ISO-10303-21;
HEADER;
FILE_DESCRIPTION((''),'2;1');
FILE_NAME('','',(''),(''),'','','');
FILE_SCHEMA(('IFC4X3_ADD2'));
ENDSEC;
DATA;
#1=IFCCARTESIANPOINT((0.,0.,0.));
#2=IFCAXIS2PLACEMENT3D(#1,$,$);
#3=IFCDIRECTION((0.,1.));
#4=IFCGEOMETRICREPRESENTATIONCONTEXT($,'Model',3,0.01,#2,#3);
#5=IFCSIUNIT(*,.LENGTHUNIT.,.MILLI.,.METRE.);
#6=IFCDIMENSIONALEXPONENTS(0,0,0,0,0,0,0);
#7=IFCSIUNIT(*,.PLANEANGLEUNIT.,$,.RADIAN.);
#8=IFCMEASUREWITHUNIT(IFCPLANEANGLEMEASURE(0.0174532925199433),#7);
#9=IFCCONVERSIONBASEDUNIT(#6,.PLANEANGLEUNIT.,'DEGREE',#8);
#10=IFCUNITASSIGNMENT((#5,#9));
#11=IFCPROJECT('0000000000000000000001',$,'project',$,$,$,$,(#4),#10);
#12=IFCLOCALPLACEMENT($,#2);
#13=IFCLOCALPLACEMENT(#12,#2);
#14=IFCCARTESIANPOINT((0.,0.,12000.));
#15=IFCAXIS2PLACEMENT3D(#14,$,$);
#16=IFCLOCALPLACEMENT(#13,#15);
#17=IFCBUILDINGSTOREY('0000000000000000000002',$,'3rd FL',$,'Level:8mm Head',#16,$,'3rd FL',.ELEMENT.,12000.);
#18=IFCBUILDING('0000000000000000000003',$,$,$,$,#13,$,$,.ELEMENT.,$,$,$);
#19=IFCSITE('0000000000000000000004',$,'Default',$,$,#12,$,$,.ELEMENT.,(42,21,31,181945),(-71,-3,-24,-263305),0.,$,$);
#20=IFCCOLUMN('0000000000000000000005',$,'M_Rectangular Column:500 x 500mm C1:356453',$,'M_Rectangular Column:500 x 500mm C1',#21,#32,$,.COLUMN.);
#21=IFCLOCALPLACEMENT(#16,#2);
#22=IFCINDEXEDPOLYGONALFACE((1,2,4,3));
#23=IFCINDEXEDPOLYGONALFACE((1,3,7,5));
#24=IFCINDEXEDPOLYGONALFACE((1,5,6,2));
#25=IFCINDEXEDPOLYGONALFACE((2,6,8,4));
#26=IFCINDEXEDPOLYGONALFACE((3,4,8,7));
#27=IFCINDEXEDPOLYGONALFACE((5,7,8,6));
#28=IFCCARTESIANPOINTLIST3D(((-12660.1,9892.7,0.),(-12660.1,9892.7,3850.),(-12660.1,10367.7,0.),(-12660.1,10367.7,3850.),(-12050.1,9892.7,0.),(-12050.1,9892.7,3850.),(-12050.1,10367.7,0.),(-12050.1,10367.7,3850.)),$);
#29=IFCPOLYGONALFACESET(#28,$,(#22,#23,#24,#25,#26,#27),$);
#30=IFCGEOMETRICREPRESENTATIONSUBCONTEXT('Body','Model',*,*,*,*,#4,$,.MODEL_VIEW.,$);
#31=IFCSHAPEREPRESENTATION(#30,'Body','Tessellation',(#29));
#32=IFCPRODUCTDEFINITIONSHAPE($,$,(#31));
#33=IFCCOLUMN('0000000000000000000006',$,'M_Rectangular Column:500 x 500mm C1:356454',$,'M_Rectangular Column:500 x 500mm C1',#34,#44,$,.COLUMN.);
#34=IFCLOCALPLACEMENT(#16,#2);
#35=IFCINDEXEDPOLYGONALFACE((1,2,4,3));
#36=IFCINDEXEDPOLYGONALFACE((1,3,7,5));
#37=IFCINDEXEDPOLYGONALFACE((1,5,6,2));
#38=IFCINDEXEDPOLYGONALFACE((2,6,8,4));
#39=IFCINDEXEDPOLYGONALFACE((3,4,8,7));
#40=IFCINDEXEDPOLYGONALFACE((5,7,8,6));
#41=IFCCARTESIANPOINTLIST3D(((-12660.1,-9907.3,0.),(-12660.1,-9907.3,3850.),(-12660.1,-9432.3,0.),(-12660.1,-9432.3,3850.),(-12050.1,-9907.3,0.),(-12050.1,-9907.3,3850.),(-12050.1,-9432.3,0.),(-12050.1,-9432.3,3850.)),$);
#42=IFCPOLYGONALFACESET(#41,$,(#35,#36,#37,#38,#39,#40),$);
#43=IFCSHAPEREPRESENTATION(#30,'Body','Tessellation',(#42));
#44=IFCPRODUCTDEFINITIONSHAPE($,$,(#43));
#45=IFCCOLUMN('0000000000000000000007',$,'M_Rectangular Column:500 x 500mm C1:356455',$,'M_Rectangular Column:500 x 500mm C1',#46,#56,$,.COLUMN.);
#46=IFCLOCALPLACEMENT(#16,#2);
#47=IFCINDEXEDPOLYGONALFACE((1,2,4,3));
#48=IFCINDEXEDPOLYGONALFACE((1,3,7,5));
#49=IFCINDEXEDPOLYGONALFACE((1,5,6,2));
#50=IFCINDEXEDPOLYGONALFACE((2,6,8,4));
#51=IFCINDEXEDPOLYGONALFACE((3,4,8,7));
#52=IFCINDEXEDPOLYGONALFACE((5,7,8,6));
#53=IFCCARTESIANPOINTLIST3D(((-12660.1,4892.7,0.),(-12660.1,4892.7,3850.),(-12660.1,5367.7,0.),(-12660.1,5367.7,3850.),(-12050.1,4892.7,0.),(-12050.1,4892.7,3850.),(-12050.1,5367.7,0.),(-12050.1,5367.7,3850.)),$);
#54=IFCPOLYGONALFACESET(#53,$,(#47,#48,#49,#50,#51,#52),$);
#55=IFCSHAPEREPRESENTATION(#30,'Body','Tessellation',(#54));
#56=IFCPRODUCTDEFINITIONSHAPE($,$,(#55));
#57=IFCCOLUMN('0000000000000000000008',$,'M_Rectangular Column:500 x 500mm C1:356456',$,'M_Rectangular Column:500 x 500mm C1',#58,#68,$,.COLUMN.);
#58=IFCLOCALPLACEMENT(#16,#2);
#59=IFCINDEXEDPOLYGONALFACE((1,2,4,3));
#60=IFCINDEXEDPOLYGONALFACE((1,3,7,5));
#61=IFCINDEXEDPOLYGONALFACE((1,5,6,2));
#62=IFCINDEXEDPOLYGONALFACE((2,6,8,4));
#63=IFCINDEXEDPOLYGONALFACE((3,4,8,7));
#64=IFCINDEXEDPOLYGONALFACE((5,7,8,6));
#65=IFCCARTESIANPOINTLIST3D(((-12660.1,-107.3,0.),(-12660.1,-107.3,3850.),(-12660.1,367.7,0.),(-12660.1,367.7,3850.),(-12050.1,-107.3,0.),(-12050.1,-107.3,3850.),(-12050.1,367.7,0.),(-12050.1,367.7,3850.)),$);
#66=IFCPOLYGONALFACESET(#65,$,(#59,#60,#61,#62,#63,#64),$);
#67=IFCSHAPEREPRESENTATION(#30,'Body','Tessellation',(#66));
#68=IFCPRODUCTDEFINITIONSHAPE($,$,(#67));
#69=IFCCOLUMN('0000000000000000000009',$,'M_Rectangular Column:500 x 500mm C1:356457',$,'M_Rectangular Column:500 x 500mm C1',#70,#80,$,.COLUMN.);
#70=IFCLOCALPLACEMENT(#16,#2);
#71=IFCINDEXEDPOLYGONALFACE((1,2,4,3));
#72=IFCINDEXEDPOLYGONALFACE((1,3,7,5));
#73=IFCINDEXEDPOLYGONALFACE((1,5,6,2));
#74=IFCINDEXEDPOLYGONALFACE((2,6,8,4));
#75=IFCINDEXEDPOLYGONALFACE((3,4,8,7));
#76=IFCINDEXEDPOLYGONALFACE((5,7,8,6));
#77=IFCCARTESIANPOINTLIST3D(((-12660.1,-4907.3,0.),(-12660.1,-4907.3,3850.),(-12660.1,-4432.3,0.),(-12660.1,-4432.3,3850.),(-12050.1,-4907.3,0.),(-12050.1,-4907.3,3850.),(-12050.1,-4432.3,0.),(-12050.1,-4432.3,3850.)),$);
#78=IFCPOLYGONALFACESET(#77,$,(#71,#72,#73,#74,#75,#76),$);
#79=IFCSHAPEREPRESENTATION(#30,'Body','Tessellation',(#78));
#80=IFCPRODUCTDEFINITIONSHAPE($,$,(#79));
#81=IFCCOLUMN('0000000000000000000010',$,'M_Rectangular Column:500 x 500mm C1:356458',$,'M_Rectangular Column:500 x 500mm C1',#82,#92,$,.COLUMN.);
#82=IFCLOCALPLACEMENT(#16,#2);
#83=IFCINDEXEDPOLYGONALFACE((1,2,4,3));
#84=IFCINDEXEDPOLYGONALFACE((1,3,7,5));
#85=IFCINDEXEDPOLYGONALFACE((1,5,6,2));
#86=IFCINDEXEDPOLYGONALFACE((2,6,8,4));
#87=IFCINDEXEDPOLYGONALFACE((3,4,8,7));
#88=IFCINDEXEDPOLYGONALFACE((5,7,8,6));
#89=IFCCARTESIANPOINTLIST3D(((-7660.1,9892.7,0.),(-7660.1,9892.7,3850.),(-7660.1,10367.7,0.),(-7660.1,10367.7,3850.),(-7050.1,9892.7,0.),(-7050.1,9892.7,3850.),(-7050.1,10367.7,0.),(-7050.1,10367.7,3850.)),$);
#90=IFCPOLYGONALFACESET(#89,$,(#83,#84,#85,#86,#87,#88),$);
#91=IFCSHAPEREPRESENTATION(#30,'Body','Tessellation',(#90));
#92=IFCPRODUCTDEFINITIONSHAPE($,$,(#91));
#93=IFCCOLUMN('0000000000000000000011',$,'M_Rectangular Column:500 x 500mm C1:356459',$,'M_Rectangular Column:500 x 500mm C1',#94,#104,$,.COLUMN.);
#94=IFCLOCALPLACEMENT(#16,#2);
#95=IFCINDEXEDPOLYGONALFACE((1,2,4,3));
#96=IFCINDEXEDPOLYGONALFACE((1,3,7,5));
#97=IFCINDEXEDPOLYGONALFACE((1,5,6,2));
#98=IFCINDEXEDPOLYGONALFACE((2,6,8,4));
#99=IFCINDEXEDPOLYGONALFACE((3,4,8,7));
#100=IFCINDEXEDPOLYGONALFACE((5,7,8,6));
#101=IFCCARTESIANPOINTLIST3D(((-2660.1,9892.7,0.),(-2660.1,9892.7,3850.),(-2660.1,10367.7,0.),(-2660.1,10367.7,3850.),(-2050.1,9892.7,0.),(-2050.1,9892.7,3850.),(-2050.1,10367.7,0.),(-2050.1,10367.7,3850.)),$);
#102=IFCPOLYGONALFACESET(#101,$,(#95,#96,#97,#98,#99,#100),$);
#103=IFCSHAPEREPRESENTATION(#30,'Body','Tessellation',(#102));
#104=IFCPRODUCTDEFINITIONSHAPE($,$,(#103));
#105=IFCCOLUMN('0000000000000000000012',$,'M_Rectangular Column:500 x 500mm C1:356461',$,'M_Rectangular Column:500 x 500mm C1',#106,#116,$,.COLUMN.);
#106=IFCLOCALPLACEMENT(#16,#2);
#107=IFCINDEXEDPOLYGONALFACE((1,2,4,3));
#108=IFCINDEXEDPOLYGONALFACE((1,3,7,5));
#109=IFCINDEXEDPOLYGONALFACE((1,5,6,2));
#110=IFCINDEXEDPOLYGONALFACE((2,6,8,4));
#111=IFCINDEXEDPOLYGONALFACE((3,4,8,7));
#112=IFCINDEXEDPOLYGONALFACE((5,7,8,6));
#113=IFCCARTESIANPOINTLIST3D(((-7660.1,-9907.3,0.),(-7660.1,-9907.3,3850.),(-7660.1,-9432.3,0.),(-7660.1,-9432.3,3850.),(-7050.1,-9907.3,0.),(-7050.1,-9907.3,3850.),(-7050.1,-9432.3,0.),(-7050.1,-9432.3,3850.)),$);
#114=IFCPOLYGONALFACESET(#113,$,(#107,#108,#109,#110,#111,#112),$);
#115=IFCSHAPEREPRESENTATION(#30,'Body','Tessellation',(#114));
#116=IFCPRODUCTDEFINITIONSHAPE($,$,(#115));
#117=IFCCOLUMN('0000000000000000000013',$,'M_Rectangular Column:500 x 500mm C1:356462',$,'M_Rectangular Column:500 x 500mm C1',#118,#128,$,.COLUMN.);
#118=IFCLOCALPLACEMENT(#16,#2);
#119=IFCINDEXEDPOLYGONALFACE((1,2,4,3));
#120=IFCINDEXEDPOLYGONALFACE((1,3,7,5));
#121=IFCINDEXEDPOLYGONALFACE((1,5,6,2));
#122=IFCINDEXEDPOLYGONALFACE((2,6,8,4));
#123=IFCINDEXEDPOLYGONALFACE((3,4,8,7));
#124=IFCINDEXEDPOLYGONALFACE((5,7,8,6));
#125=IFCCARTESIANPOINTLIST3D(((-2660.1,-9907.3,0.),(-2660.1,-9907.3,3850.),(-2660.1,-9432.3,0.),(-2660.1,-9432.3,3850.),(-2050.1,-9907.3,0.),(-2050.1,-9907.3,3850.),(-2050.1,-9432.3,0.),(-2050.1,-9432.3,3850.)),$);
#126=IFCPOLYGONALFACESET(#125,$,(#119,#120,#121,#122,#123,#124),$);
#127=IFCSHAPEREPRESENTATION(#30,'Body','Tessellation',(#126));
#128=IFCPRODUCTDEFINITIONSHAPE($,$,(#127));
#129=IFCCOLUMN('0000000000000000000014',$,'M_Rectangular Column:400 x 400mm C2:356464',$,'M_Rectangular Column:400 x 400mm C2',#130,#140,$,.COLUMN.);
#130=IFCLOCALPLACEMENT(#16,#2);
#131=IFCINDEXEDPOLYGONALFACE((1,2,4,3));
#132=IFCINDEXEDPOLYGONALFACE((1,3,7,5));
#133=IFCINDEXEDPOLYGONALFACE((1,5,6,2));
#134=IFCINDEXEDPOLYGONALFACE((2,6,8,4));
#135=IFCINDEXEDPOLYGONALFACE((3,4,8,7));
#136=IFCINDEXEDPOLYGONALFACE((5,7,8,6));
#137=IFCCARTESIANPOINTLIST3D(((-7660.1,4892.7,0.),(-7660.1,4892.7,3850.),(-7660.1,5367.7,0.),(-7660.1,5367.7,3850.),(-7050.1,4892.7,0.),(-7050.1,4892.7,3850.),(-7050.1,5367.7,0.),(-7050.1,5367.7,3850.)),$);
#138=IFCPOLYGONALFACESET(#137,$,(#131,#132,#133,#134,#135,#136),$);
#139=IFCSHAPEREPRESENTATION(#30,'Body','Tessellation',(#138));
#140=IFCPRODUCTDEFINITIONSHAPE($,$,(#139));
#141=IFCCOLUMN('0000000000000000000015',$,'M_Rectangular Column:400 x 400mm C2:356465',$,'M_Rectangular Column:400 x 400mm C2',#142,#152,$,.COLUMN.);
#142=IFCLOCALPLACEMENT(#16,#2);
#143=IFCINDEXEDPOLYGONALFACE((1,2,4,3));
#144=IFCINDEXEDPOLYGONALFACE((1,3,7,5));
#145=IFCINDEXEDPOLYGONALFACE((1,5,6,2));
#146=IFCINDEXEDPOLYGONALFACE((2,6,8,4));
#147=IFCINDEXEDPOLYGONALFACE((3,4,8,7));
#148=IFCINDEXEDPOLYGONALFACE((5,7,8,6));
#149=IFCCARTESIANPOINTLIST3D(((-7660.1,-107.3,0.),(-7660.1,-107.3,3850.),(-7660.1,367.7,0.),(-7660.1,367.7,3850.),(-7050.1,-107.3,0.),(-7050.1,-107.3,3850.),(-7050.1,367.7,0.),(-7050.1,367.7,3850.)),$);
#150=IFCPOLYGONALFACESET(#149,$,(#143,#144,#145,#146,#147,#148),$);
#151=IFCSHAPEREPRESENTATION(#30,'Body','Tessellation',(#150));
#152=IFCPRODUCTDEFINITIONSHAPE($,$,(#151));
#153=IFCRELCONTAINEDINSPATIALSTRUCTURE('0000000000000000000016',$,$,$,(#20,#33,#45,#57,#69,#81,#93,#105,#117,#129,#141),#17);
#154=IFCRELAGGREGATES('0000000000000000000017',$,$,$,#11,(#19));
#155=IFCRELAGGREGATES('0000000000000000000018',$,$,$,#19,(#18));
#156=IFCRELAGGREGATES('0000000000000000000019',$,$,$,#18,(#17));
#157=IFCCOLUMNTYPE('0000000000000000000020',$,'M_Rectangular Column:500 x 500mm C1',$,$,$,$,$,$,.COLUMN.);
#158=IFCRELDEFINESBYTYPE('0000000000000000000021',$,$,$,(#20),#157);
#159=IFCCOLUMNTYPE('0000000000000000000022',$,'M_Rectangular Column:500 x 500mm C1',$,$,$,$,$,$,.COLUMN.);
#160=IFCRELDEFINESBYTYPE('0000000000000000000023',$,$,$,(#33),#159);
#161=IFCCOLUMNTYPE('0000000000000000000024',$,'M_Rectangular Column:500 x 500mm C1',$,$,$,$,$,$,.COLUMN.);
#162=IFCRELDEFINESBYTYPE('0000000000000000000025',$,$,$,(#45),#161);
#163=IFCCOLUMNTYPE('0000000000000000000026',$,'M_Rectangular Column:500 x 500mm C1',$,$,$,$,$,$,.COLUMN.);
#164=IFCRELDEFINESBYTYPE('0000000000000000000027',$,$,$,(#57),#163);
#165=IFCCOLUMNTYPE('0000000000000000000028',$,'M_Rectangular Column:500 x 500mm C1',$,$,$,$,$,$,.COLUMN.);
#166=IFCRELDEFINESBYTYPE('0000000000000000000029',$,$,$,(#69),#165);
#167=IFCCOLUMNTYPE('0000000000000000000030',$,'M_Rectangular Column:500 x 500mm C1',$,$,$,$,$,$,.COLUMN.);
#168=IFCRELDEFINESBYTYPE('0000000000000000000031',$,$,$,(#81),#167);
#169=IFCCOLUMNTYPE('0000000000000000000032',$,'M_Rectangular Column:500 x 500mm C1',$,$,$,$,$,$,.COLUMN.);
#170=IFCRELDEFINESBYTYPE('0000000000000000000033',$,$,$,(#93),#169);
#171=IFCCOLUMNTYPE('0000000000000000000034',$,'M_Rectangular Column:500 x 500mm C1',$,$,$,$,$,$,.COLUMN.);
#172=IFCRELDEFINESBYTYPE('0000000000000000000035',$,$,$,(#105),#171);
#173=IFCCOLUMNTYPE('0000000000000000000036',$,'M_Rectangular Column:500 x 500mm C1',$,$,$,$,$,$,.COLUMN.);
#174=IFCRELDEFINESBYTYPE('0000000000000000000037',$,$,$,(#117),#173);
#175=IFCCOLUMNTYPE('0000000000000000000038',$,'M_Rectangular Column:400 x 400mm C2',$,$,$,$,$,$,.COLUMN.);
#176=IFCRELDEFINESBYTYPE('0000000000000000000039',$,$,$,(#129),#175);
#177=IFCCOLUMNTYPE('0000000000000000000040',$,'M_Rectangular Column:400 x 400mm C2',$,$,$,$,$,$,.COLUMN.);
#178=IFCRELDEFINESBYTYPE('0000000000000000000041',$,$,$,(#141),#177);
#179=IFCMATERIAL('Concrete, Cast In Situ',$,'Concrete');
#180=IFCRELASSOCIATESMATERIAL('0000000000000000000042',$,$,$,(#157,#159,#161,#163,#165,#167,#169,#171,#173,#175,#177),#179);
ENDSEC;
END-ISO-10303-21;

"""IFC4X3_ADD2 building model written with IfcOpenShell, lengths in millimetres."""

from ifc_helpers import new_model, entity, si_unit, converted_unit, direction, frame, frame_2d, origin, origin_2d_with_axis, place, context, subcontext, project, spatial, rectangle, extrude, source, transform, mapped, material, material_profile, profile_set, type_object, type_shapes, element, save


model = new_model("IFC4X3_ADD2")

# Units and contexts
model_context = context("Model", 3, precision=0.01, world=origin(), true_north=direction((0.0, 1.0)))
body_context = subcontext(model_context, "Body", "Model", "MODEL_VIEW")
ifc_project = project(units=[si_unit("LENGTHUNIT", "METRE", prefix="MILLI"), converted_unit("PLANEANGLEUNIT", "DEGREE", entity("IfcPlaneAngleMeasure", 0.0174532925199433), si_unit("PLANEANGLEUNIT", "RADIAN"), dimensions=[0, 0, 0, 0, 0, 0, 0])], contexts=[model_context])

# Site, building, storey
site_placement = place(None, origin())
site = spatial("IfcSite", under=ifc_project, at=site_placement, Name="Default", CompositionType="ELEMENT", RefLatitude=(42, 21, 31, 181945), RefLongitude=(-71, -3, -24, -263305), RefElevation=0.0)
building_placement = place(site_placement, origin())
building = spatial("IfcBuilding", under=site, at=building_placement, CompositionType="ELEMENT")
storey_placement = place(building_placement, frame((0.0, 0.0, 12000.0)))
storey = spatial("IfcBuildingStorey", under=building, at=storey_placement, Name="3rd FL", ObjectType="Level:8mm Head", LongName="3rd FL", CompositionType="ELEMENT", Elevation=12000.0)

# Columns
ifc_material_1 = material(Name="Concrete, Cast In Situ", Category="Concrete")
ifc_material_profile_1 = material_profile(ifc_material_1, rectangle(XDim=610.0, YDim=475.0, at=frame_2d((0.0, 0.0), x_axis=(1.0, 0.0))), Name="500 x 500mm C1")
ifc_profile_set_1 = profile_set([ifc_material_profile_1], Name="500 x 500mm C1")
column_type_1 = type_object("IfcColumnType", Name="M_Rectangular Column:500 x 500mm C1", PredefinedType="COLUMN", material=ifc_profile_set_1)
shared_shape_1 = source(origin(), body_context, "Body", "SweptSolid", [
    extrude(rectangle(XDim=610.0, YDim=475.0, at=frame_2d((0.0, 0.0), x_axis=(1.0, 0.0))), frame((-12355.1, 10130.2, 12000.0), z_axis=(0.0, 0.0, 1.0), x_axis=(-1.0, 0.0, 0.0)), (0.0, 0.0, 1.0), 3850.0),
])
type_shapes(column_type_1, [shared_shape_1])
column_1_placement = place(storey_placement, frame((0.0, 0.0, -12000.0)))
element("IfcColumn", 1, at=column_1_placement, inside=storey, type_object=column_type_1, Name="M_Rectangular Column:500 x 500mm C1:356453", ObjectType="M_Rectangular Column:500 x 500mm C1", PredefinedType="COLUMN", context=body_context, shape_type="MappedRepresentation", body=[
    mapped(shared_shape_1, transform((0.0, 0.0, 0.0), scale=1.0)),
])
column_type_2 = type_object("IfcColumnType", Name="M_Rectangular Column:500 x 500mm C1", PredefinedType="COLUMN", material=ifc_profile_set_1)
shared_shape_2 = source(origin(), body_context, "Body", "SweptSolid", [
    extrude(rectangle(XDim=610.0, YDim=475.0, at=frame_2d((0.0, 0.0), x_axis=(1.0, 0.0))), frame((-12355.1, -9669.8, 12000.0), z_axis=(0.0, 0.0, 1.0), x_axis=(-1.0, 0.0, 0.0)), (0.0, 0.0, 1.0), 3850.0),
])
type_shapes(column_type_2, [shared_shape_2])
column_2_placement = place(storey_placement, frame((0.0, 0.0, -12000.0)))
element("IfcColumn", 2, at=column_2_placement, inside=storey, type_object=column_type_2, Name="M_Rectangular Column:500 x 500mm C1:356454", ObjectType="M_Rectangular Column:500 x 500mm C1", PredefinedType="COLUMN", context=body_context, shape_type="MappedRepresentation", body=[
    mapped(shared_shape_2, transform((0.0, 0.0, 0.0), scale=1.0)),
])
column_type_3 = type_object("IfcColumnType", Name="M_Rectangular Column:500 x 500mm C1", PredefinedType="COLUMN", material=ifc_profile_set_1)
shared_shape_3 = source(origin(), body_context, "Body", "SweptSolid", [
    extrude(rectangle(XDim=610.0, YDim=475.0, at=frame_2d((0.0, 0.0), x_axis=(1.0, 0.0))), frame((-12355.1, 5130.2, 12000.0), z_axis=(0.0, 0.0, 1.0), x_axis=(-1.0, 0.0, 0.0)), (0.0, 0.0, 1.0), 3850.0),
])
type_shapes(column_type_3, [shared_shape_3])
column_3_placement = place(storey_placement, frame((0.0, 0.0, -12000.0)))
element("IfcColumn", 3, at=column_3_placement, inside=storey, type_object=column_type_3, Name="M_Rectangular Column:500 x 500mm C1:356455", ObjectType="M_Rectangular Column:500 x 500mm C1", PredefinedType="COLUMN", context=body_context, shape_type="MappedRepresentation", body=[
    mapped(shared_shape_3, transform((0.0, 0.0, 0.0), scale=1.0)),
])
column_type_4 = type_object("IfcColumnType", Name="M_Rectangular Column:500 x 500mm C1", PredefinedType="COLUMN", material=ifc_profile_set_1)
shared_shape_4 = source(origin(), body_context, "Body", "SweptSolid", [
    extrude(rectangle(XDim=610.0, YDim=475.0, at=origin_2d_with_axis()), frame((-12355.1, 130.2, 12000.0), z_axis=(0.0, 0.0, 1.0), x_axis=(-1.0, 0.0, 0.0)), (0.0, 0.0, 1.0), 3850.0),
])
type_shapes(column_type_4, [shared_shape_4])
column_4_placement = place(storey_placement, frame((0.0, 0.0, -12000.0)))
element("IfcColumn", 4, at=column_4_placement, inside=storey, type_object=column_type_4, Name="M_Rectangular Column:500 x 500mm C1:356456", ObjectType="M_Rectangular Column:500 x 500mm C1", PredefinedType="COLUMN", context=body_context, shape_type="MappedRepresentation", body=[
    mapped(shared_shape_4, transform((0.0, 0.0, 0.0), scale=1.0)),
])
column_type_5 = type_object("IfcColumnType", Name="M_Rectangular Column:500 x 500mm C1", PredefinedType="COLUMN", material=ifc_profile_set_1)
shared_shape_5 = source(origin(), body_context, "Body", "SweptSolid", [
    extrude(rectangle(XDim=610.0, YDim=475.0, at=frame_2d((0.0, 0.0), x_axis=(1.0, 0.0))), frame((-12355.1, -4669.8, 12000.0), z_axis=(0.0, 0.0, 1.0), x_axis=(-1.0, 0.0, 0.0)), (0.0, 0.0, 1.0), 3850.0),
])
type_shapes(column_type_5, [shared_shape_5])
column_5_placement = place(storey_placement, frame((0.0, 0.0, -12000.0)))
element("IfcColumn", 5, at=column_5_placement, inside=storey, type_object=column_type_5, Name="M_Rectangular Column:500 x 500mm C1:356457", ObjectType="M_Rectangular Column:500 x 500mm C1", PredefinedType="COLUMN", context=body_context, shape_type="MappedRepresentation", body=[
    mapped(shared_shape_5, transform((0.0, 0.0, 0.0), scale=1.0)),
])
column_type_6 = type_object("IfcColumnType", Name="M_Rectangular Column:500 x 500mm C1", PredefinedType="COLUMN", material=ifc_profile_set_1)
shared_shape_6 = source(origin(), body_context, "Body", "SweptSolid", [
    extrude(rectangle(XDim=610.0, YDim=475.0, at=frame_2d((0.0, 0.0), x_axis=(1.0, 0.0))), frame((-7355.1, 10130.2, 12000.0), z_axis=(0.0, 0.0, 1.0), x_axis=(-1.0, 0.0, 0.0)), (0.0, 0.0, 1.0), 3850.0),
])
type_shapes(column_type_6, [shared_shape_6])
column_6_placement = place(storey_placement, frame((0.0, 0.0, -12000.0)))
element("IfcColumn", 6, at=column_6_placement, inside=storey, type_object=column_type_6, Name="M_Rectangular Column:500 x 500mm C1:356458", ObjectType="M_Rectangular Column:500 x 500mm C1", PredefinedType="COLUMN", context=body_context, shape_type="MappedRepresentation", body=[
    mapped(shared_shape_6, transform((0.0, 0.0, 0.0), scale=1.0)),
])
column_type_7 = type_object("IfcColumnType", Name="M_Rectangular Column:500 x 500mm C1", PredefinedType="COLUMN", material=ifc_profile_set_1)
shared_shape_7 = source(origin(), body_context, "Body", "SweptSolid", [
    extrude(rectangle(XDim=610.0, YDim=475.0, at=frame_2d((0.0, 0.0), x_axis=(1.0, 0.0))), frame((-2355.1, 10130.2, 12000.0), z_axis=(0.0, 0.0, 1.0), x_axis=(-1.0, 0.0, 0.0)), (0.0, 0.0, 1.0), 3850.0),
])
type_shapes(column_type_7, [shared_shape_7])
column_7_placement = place(storey_placement, frame((0.0, 0.0, -12000.0)))
element("IfcColumn", 7, at=column_7_placement, inside=storey, type_object=column_type_7, Name="M_Rectangular Column:500 x 500mm C1:356459", ObjectType="M_Rectangular Column:500 x 500mm C1", PredefinedType="COLUMN", context=body_context, shape_type="MappedRepresentation", body=[
    mapped(shared_shape_7, transform((0.0, 0.0, 0.0), scale=1.0)),
])
column_type_8 = type_object("IfcColumnType", Name="M_Rectangular Column:500 x 500mm C1", PredefinedType="COLUMN", material=ifc_profile_set_1)
shared_shape_8 = source(origin(), body_context, "Body", "SweptSolid", [
    extrude(rectangle(XDim=610.0, YDim=475.0, at=origin_2d_with_axis()), frame((-7355.1, -9669.8, 12000.0), z_axis=(0.0, 0.0, 1.0), x_axis=(-1.0, 0.0, 0.0)), (0.0, 0.0, 1.0), 3850.0),
])
type_shapes(column_type_8, [shared_shape_8])
column_8_placement = place(storey_placement, frame((0.0, 0.0, -12000.0)))
element("IfcColumn", 8, at=column_8_placement, inside=storey, type_object=column_type_8, Name="M_Rectangular Column:500 x 500mm C1:356461", ObjectType="M_Rectangular Column:500 x 500mm C1", PredefinedType="COLUMN", context=body_context, shape_type="MappedRepresentation", body=[
    mapped(shared_shape_8, transform((0.0, 0.0, 0.0), scale=1.0)),
])
column_type_9 = type_object("IfcColumnType", Name="M_Rectangular Column:500 x 500mm C1", PredefinedType="COLUMN", material=ifc_profile_set_1)
shared_shape_9 = source(origin(), body_context, "Body", "SweptSolid", [
    extrude(rectangle(XDim=610.0, YDim=475.0, at=frame_2d((0.0, 0.0), x_axis=(1.0, 0.0))), frame((-2355.1, -9669.8, 12000.0), z_axis=(0.0, 0.0, 1.0), x_axis=(-1.0, 0.0, 0.0)), (0.0, 0.0, 1.0), 3850.0),
])
type_shapes(column_type_9, [shared_shape_9])
column_9_placement = place(storey_placement, frame((0.0, 0.0, -12000.0)))
element("IfcColumn", 9, at=column_9_placement, inside=storey, type_object=column_type_9, Name="M_Rectangular Column:500 x 500mm C1:356462", ObjectType="M_Rectangular Column:500 x 500mm C1", PredefinedType="COLUMN", context=body_context, shape_type="MappedRepresentation", body=[
    mapped(shared_shape_9, transform((0.0, 0.0, 0.0), scale=1.0)),
])
ifc_material_profile_2 = material_profile(ifc_material_1, rectangle(XDim=610.0, YDim=475.0, at=origin_2d_with_axis()), Name="400 x 400mm C2")
ifc_profile_set_2 = profile_set([ifc_material_profile_2], Name="400 x 400mm C2")
column_type_10 = type_object("IfcColumnType", Name="M_Rectangular Column:400 x 400mm C2", PredefinedType="COLUMN", material=ifc_profile_set_2)
shared_shape_10 = source(origin(), body_context, "Body", "SweptSolid", [
    extrude(rectangle(XDim=610.0, YDim=475.0, at=frame_2d((0.0, 0.0), x_axis=(1.0, 0.0))), frame((-7355.1, 5130.2, 12000.0), z_axis=(0.0, 0.0, 1.0), x_axis=(-1.0, 0.0, 0.0)), (0.0, 0.0, 1.0), 3850.0),
])
type_shapes(column_type_10, [shared_shape_10])
column_10_placement = place(storey_placement, frame((0.0, 0.0, -12000.0)))
element("IfcColumn", 10, at=column_10_placement, inside=storey, type_object=column_type_10, Name="M_Rectangular Column:400 x 400mm C2:356464", ObjectType="M_Rectangular Column:400 x 400mm C2", PredefinedType="COLUMN", context=body_context, shape_type="MappedRepresentation", body=[
    mapped(shared_shape_10, transform((0.0, 0.0, 0.0), scale=1.0)),
])
column_type_11 = type_object("IfcColumnType", Name="M_Rectangular Column:400 x 400mm C2", PredefinedType="COLUMN", material=ifc_profile_set_2)
shared_shape_11 = source(origin(), body_context, "Body", "SweptSolid", [
    extrude(rectangle(XDim=610.0, YDim=475.0, at=origin_2d_with_axis()), frame((-7355.1, 130.2, 12000.0), z_axis=(0.0, 0.0, 1.0), x_axis=(-1.0, 0.0, 0.0)), (0.0, 0.0, 1.0), 3850.0),
])
type_shapes(column_type_11, [shared_shape_11])
column_11_placement = place(storey_placement, frame((0.0, 0.0, -12000.0)))
element("IfcColumn", 11, at=column_11_placement, inside=storey, type_object=column_type_11, Name="M_Rectangular Column:400 x 400mm C2:356465", ObjectType="M_Rectangular Column:400 x 400mm C2", PredefinedType="COLUMN", context=body_context, shape_type="MappedRepresentation", body=[
    mapped(shared_shape_11, transform((0.0, 0.0, 0.0), scale=1.0)),
])

save(model, "model.ifc")
